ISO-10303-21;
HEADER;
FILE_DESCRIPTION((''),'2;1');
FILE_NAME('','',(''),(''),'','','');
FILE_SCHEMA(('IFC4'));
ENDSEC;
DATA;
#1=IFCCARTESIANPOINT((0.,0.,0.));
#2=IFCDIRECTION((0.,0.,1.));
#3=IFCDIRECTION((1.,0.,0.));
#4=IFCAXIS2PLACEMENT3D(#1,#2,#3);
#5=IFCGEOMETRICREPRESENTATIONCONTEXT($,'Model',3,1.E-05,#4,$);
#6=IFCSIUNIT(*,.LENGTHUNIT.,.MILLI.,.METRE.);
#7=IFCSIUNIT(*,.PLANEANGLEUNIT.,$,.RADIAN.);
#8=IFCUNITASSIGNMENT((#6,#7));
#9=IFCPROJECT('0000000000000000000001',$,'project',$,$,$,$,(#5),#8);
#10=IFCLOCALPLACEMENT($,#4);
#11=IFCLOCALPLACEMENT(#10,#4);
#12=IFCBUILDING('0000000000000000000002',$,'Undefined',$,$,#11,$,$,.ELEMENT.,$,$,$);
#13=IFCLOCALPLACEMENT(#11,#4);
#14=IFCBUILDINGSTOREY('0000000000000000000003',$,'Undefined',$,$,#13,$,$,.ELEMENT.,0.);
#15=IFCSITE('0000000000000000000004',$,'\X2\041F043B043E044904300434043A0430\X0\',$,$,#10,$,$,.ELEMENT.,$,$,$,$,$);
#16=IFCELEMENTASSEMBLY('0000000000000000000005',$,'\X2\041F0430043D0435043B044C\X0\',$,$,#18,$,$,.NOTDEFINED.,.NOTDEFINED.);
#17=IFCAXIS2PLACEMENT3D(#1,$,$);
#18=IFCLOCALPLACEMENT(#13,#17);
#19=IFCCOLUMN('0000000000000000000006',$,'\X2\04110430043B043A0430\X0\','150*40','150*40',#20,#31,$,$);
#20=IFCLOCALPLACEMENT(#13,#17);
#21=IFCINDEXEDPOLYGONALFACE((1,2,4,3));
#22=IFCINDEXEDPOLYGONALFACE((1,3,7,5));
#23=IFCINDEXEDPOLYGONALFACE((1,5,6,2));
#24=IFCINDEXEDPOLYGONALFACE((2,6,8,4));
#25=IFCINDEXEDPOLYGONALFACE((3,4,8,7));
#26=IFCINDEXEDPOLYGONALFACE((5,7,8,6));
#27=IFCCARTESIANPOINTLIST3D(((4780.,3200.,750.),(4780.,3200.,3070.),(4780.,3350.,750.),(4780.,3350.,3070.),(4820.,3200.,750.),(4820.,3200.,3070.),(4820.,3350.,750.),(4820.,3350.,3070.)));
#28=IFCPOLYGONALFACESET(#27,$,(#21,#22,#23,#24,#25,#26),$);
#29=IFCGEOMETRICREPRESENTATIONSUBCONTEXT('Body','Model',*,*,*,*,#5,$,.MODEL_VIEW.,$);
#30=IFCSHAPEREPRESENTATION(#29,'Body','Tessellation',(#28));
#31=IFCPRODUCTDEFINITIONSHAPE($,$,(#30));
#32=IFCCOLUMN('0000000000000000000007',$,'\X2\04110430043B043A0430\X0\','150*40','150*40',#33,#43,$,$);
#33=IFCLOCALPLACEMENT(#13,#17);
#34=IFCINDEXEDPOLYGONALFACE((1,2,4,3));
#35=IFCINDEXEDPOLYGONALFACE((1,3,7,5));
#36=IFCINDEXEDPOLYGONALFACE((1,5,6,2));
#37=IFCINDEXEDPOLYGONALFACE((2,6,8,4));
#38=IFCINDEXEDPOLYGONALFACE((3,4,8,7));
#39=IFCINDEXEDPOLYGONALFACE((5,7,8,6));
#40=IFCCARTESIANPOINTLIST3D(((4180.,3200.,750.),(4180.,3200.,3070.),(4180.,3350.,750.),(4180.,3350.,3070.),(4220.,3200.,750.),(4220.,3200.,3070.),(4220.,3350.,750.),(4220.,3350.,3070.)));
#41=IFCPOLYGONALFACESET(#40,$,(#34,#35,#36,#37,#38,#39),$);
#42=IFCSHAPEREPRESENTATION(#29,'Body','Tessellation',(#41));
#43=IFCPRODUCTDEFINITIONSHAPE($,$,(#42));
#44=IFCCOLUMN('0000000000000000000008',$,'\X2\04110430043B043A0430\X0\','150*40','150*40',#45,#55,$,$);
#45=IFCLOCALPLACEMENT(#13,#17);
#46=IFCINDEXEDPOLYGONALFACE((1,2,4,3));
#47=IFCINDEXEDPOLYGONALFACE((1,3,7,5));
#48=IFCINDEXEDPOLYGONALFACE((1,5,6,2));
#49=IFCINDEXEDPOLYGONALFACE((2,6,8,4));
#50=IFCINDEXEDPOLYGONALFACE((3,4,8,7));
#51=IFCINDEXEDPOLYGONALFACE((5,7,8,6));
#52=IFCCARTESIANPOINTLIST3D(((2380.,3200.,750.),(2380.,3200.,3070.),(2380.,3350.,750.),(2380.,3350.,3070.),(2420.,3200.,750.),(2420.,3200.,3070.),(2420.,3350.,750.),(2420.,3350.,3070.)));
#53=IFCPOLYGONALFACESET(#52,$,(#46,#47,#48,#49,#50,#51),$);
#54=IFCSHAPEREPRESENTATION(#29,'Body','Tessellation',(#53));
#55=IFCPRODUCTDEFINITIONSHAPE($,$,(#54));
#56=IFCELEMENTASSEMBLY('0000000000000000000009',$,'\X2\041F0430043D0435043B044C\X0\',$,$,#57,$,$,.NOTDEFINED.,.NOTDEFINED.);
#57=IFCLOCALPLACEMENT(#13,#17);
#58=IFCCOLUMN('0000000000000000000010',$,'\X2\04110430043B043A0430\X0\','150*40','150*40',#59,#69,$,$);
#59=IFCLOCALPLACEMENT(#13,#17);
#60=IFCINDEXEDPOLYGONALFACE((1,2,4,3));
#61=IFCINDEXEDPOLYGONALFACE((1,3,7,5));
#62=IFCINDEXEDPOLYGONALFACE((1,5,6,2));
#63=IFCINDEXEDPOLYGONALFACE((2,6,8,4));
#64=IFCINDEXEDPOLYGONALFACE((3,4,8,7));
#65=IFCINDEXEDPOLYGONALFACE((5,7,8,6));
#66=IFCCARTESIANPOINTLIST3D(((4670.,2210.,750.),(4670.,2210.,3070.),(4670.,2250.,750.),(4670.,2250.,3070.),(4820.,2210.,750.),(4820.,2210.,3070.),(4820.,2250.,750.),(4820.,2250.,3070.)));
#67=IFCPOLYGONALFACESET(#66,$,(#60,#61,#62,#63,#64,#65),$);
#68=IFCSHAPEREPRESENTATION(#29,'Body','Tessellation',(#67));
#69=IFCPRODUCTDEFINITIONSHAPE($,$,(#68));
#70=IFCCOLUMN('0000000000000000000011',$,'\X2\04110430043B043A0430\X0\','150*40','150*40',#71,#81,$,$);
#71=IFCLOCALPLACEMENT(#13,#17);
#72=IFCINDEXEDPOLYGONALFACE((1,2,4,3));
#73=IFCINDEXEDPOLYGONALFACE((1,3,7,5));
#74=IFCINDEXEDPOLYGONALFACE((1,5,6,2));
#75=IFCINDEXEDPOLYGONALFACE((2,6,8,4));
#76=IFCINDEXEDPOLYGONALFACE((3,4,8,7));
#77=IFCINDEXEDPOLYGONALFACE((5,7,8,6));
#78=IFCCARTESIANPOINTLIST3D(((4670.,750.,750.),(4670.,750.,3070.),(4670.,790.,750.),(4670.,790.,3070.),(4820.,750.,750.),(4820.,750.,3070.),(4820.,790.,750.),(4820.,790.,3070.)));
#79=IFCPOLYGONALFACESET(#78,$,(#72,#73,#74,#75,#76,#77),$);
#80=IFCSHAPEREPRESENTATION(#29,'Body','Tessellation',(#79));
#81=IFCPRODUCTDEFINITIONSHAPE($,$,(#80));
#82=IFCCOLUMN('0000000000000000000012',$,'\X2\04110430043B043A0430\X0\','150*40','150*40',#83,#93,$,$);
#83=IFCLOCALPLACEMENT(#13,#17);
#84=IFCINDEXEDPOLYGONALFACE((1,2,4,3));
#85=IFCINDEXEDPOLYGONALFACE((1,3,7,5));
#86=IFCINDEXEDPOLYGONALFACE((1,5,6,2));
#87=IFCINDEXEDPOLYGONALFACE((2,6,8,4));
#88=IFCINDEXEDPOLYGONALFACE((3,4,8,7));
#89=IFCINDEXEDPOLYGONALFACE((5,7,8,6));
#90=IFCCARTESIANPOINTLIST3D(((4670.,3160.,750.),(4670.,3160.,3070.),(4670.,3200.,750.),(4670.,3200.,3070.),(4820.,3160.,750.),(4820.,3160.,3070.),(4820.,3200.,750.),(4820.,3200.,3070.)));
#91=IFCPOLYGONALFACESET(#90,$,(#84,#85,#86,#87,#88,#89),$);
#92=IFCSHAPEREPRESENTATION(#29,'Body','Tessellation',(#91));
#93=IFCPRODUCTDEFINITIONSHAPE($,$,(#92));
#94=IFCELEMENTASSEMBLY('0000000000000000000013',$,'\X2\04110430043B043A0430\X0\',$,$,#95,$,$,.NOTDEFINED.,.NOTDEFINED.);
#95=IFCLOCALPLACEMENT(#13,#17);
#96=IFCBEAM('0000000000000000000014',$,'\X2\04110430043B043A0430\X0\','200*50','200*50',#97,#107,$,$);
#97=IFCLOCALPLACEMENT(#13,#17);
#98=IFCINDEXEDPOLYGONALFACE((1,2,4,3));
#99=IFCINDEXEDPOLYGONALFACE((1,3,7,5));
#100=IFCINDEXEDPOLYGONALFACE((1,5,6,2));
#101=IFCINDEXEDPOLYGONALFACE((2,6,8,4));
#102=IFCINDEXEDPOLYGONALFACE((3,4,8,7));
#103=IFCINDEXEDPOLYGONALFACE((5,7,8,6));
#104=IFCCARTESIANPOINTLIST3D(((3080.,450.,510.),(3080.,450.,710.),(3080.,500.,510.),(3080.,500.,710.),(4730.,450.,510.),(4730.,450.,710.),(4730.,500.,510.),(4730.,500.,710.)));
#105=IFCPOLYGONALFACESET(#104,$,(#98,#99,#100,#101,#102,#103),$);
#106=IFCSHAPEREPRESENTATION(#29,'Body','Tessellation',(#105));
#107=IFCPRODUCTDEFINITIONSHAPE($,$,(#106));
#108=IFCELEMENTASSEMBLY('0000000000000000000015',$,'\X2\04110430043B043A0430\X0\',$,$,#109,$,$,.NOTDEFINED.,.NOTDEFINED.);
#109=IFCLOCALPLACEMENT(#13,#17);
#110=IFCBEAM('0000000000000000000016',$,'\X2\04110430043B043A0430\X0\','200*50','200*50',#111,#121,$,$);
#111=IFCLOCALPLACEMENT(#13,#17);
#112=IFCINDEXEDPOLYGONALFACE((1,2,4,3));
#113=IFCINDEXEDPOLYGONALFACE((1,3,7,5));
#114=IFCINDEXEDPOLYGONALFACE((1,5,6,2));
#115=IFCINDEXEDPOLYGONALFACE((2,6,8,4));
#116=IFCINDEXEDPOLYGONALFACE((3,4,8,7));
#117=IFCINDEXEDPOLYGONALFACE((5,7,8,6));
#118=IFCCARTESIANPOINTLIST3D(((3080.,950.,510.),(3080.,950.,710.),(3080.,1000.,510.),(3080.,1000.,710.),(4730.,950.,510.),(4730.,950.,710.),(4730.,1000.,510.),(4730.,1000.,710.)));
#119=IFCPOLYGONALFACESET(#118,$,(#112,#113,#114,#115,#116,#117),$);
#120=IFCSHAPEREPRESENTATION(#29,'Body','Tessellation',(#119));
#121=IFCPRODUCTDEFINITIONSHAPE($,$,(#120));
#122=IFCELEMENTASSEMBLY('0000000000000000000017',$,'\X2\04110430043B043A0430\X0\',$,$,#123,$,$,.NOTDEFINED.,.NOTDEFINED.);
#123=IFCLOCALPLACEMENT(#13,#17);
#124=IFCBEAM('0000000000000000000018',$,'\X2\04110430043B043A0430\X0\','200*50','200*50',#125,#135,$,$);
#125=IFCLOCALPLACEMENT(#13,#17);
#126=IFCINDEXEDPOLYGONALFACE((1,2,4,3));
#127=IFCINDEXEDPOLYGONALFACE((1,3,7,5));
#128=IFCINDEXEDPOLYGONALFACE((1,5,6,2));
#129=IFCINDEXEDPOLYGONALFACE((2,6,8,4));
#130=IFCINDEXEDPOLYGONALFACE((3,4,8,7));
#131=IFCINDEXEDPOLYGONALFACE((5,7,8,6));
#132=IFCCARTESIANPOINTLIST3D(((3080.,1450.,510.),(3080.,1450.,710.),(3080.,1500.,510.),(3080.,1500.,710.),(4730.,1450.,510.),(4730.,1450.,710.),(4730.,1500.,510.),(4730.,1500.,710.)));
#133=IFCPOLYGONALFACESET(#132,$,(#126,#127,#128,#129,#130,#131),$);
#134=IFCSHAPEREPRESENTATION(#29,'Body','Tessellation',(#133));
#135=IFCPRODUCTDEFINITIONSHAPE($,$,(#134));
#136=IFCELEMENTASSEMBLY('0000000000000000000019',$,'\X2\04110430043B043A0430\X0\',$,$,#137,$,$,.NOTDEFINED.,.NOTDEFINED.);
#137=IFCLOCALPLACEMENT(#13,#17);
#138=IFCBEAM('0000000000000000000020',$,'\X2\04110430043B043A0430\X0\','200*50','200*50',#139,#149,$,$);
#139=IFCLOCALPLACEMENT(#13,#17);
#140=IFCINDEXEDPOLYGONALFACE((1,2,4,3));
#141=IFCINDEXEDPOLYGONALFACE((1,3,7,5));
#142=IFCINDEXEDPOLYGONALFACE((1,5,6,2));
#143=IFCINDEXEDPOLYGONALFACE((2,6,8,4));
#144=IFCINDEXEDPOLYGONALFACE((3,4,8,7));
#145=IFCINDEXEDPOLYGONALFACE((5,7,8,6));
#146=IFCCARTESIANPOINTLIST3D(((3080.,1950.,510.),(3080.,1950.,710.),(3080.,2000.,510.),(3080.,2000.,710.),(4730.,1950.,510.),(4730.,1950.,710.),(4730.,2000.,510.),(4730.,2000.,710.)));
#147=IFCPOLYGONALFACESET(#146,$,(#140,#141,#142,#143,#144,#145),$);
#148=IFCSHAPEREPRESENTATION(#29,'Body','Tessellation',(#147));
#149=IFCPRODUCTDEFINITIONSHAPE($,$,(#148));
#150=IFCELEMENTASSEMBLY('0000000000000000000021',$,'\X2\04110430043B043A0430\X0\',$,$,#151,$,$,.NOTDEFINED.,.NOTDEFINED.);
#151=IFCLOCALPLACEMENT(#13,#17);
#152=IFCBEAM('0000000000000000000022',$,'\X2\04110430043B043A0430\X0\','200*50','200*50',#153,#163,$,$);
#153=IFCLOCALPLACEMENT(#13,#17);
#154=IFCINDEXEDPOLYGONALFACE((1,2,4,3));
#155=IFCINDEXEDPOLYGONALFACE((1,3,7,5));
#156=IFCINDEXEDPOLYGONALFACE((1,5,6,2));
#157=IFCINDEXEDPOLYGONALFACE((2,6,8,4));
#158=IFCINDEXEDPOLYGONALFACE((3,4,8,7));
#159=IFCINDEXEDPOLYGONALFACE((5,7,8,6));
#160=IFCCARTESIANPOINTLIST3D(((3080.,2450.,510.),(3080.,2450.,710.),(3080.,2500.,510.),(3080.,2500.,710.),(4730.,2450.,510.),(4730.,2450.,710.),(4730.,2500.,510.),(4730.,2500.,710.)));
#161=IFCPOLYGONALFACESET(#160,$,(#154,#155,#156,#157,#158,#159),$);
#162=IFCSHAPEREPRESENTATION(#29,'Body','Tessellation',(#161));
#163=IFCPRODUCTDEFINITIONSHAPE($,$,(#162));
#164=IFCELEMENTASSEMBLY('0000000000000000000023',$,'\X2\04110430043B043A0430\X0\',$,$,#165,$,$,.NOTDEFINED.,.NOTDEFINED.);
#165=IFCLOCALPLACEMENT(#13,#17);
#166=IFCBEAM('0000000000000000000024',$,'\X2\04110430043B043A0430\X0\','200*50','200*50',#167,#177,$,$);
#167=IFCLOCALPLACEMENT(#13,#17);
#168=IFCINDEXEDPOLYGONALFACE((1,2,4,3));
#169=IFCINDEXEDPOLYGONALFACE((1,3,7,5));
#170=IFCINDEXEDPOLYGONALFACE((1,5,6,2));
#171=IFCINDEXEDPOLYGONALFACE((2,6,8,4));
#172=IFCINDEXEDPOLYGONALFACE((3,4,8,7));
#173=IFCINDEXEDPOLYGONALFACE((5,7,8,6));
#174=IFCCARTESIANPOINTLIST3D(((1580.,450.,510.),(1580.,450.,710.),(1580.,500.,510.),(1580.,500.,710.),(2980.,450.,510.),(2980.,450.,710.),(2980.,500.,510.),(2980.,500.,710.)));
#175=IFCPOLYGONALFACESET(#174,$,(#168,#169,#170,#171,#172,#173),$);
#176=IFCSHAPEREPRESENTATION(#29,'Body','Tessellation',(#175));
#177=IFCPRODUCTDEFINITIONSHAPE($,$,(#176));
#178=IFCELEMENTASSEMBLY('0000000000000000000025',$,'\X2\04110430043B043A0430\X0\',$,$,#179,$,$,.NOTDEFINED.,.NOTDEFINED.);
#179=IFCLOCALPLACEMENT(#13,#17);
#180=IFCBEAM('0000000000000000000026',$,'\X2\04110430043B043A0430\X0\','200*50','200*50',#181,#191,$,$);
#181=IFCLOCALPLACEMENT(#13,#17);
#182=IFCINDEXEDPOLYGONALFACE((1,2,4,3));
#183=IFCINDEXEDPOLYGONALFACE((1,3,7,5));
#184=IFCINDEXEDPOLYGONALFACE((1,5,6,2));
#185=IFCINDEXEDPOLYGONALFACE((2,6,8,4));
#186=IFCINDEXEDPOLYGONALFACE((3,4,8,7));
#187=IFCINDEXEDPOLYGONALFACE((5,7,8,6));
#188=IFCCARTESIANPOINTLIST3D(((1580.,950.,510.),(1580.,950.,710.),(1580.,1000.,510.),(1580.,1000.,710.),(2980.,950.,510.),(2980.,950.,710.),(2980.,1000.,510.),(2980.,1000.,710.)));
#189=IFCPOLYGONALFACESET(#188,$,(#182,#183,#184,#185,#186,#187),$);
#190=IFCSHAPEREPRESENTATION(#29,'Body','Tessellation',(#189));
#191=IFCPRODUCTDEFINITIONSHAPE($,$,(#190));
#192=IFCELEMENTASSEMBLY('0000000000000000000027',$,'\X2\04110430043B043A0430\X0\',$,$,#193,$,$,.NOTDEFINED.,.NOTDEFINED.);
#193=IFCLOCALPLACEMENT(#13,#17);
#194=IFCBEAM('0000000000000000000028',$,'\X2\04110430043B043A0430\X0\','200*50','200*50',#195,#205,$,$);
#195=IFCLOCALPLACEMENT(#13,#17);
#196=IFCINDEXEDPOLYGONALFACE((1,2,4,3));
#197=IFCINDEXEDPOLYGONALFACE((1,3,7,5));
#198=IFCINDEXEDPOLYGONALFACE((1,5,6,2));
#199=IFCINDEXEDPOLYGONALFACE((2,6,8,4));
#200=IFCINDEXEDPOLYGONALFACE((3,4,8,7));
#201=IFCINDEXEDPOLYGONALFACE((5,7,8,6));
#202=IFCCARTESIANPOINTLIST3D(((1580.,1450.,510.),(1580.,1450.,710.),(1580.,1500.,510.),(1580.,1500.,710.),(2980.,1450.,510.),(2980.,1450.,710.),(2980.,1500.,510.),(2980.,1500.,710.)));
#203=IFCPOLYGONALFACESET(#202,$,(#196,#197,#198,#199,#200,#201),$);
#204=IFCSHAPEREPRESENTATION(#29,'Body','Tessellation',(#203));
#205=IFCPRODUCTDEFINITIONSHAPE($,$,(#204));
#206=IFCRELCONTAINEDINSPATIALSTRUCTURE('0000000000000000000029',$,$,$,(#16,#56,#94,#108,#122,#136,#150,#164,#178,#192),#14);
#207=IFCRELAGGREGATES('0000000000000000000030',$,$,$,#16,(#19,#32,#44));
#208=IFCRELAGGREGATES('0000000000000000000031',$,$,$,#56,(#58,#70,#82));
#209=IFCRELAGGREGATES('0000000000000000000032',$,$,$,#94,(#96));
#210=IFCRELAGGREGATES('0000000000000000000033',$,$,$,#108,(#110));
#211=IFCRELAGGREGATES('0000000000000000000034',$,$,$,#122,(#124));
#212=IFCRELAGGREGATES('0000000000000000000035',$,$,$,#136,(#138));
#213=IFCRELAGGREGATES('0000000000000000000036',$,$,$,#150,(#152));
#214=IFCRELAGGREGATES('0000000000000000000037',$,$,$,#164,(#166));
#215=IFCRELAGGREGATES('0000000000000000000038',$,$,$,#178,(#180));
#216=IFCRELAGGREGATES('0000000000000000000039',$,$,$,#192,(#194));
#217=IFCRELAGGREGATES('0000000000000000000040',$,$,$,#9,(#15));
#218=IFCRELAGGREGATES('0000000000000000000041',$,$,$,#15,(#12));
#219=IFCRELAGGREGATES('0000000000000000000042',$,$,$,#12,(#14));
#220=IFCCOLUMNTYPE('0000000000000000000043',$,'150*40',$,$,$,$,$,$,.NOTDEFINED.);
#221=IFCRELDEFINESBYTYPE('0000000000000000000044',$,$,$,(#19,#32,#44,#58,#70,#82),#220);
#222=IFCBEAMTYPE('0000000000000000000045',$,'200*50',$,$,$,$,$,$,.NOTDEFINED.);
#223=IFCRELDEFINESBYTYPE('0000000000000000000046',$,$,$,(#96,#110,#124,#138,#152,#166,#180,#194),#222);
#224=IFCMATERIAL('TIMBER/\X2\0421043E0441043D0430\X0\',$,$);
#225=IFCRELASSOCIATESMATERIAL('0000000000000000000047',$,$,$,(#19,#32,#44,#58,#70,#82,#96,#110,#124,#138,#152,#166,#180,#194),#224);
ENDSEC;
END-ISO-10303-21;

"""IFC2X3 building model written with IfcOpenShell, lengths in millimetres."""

from ifc_helpers import new_model, si_unit, frame, origin_with_axes, origin_2d_with_axis, place, context, subcontext, project, spatial, rectangle, extrude, material, type_object, element, aggregate, save


model = new_model("IFC2X3")

# Units and contexts
model_context = context("Model", 3, precision=1e-05, world=origin_with_axes())
body_context = subcontext(model_context, "Body", "Model", "MODEL_VIEW")
ifc_project = project(units=[si_unit("LENGTHUNIT", "METRE", prefix="MILLI"), si_unit("PLANEANGLEUNIT", "RADIAN")], contexts=[model_context])

# Site, building, storey
site_placement = place(None, origin_with_axes())
site = spatial("IfcSite", under=ifc_project, at=site_placement, Name="Площадка", CompositionType="ELEMENT")
building_placement = place(site_placement, origin_with_axes())
building = spatial("IfcBuilding", under=site, at=building_placement, Name="Undefined", CompositionType="ELEMENT")
storey_placement = place(building_placement, origin_with_axes())
storey = spatial("IfcBuildingStorey", under=building, at=storey_placement, Name="Undefined", CompositionType="ELEMENT", Elevation=0.0)

# Element assemblies, columns
assembly_1_placement = place(storey_placement, origin_with_axes())
assembly_1 = element("IfcElementAssembly", 1, at=assembly_1_placement, inside=storey, Name="Панель", AssemblyPlace="NOTDEFINED", PredefinedType="NOTDEFINED")
ifc_material_1 = material(Name="TIMBER/Сосна")
column_type = type_object("IfcColumnType", Name="150*40", PredefinedType="NOTDEFINED")
column_1_placement = place(assembly_1_placement, frame((4800.0, 3275.0, 750.0), z_axis=(0.0, 0.0, 1.0), x_axis=(0.0, 1.0, 0.0)))
column_1 = element("IfcColumn", 2, at=column_1_placement, type_object=column_type, material=ifc_material_1, Name="Балка", Description="150*40", ObjectType="150*40", context=body_context, shape_type="SweptSolid", body=[
    extrude(rectangle(XDim=40.0, YDim=150.0, at=origin_2d_with_axis()), frame((0.0, 0.0, 2320.0), z_axis=(0.0, 0.0, -1.0), x_axis=(0.0, 1.0, 0.0)), (0.0, 0.0, 1.0), 2320.0),
])
column_2_placement = place(assembly_1_placement, frame((4200.0, 3275.0, 750.0), z_axis=(0.0, 0.0, 1.0), x_axis=(0.0, 1.0, 0.0)))
column_2 = element("IfcColumn", 3, at=column_2_placement, type_object=column_type, material=ifc_material_1, Name="Балка", Description="150*40", ObjectType="150*40", context=body_context, shape_type="SweptSolid", body=[
    extrude(rectangle(XDim=40.0, YDim=150.0, at=origin_2d_with_axis()), frame((0.0, 0.0, 2320.0), z_axis=(0.0, 0.0, -1.0), x_axis=(0.0, 1.0, 0.0)), (0.0, 0.0, 1.0), 2320.0),
])
column_3_placement = place(assembly_1_placement, frame((2400.0, 3275.0, 750.0), z_axis=(0.0, 0.0, 1.0), x_axis=(0.0, 1.0, 0.0)))
column_3 = element("IfcColumn", 4, at=column_3_placement, type_object=column_type, material=ifc_material_1, Name="Балка", Description="150*40", ObjectType="150*40", context=body_context, shape_type="SweptSolid", body=[
    extrude(rectangle(XDim=40.0, YDim=150.0, at=origin_2d_with_axis()), frame((0.0, 0.0, 2320.0), z_axis=(0.0, 0.0, -1.0), x_axis=(0.0, 1.0, 0.0)), (0.0, 0.0, 1.0), 2320.0),
])
aggregate(assembly_1, [column_1, column_2, column_3])
assembly_2_placement = place(storey_placement, origin_with_axes())
assembly_2 = element("IfcElementAssembly", 5, at=assembly_2_placement, inside=storey, Name="Панель", AssemblyPlace="NOTDEFINED", PredefinedType="NOTDEFINED")
column_4_placement = place(assembly_2_placement, frame((4745.0, 2230.0, 750.0), z_axis=(0.0, 0.0, 1.0), x_axis=(-1.0, 0.0, 0.0)))
column_4 = element("IfcColumn", 6, at=column_4_placement, type_object=column_type, material=ifc_material_1, Name="Балка", Description="150*40", ObjectType="150*40", context=body_context, shape_type="SweptSolid", body=[
    extrude(rectangle(XDim=40.0, YDim=150.0, at=origin_2d_with_axis()), frame((0.0, 0.0, 2320.0), z_axis=(0.0, 0.0, -1.0), x_axis=(0.0, 1.0, 0.0)), (0.0, 0.0, 1.0), 2320.0),
])
column_5_placement = place(assembly_2_placement, frame((4745.0, 770.0, 750.0), z_axis=(0.0, 0.0, 1.0), x_axis=(-1.0, 0.0, 0.0)))
column_5 = element("IfcColumn", 7, at=column_5_placement, type_object=column_type, material=ifc_material_1, Name="Балка", Description="150*40", ObjectType="150*40", context=body_context, shape_type="SweptSolid", body=[
    extrude(rectangle(XDim=40.0, YDim=150.0, at=origin_2d_with_axis()), frame((0.0, 0.0, 2320.0), z_axis=(0.0, 0.0, -1.0), x_axis=(0.0, 1.0, 0.0)), (0.0, 0.0, 1.0), 2320.0),
])
column_6_placement = place(assembly_2_placement, frame((4745.0, 3180.0, 750.0), z_axis=(0.0, 0.0, 1.0), x_axis=(-1.0, 0.0, 0.0)))
column_6 = element("IfcColumn", 8, at=column_6_placement, type_object=column_type, material=ifc_material_1, Name="Балка", Description="150*40", ObjectType="150*40", context=body_context, shape_type="SweptSolid", body=[
    extrude(rectangle(XDim=40.0, YDim=150.0, at=origin_2d_with_axis()), frame((0.0, 0.0, 2320.0), z_axis=(0.0, 0.0, -1.0), x_axis=(0.0, 1.0, 0.0)), (0.0, 0.0, 1.0), 2320.0),
])
aggregate(assembly_2, [column_4, column_5, column_6])

# Element assemblies, beams
assembly_3_placement = place(storey_placement, origin_with_axes())
assembly_3 = element("IfcElementAssembly", 9, at=assembly_3_placement, inside=storey, Name="Балка", AssemblyPlace="NOTDEFINED", PredefinedType="NOTDEFINED")
beam_type = type_object("IfcBeamType", Name="200*50", PredefinedType="NOTDEFINED")
beam_1_placement = place(assembly_3_placement, frame((4730.0, 475.0, 610.0), z_axis=(0.0, 0.0, -1.0), x_axis=(-1.0, 0.0, 0.0)))
beam_1 = element("IfcBeam", 10, at=beam_1_placement, type_object=beam_type, material=ifc_material_1, Name="Балка", Description="200*50", ObjectType="200*50", context=body_context, shape_type="SweptSolid", body=[
    extrude(rectangle(XDim=50.0, YDim=200.0, at=origin_2d_with_axis()), frame((1650.0, 0.0, 0.0), z_axis=(-1.0, 0.0, 0.0), x_axis=(0.0, -1.0, 0.0)), (0.0, 0.0, 1.0), 1650.0),
])
aggregate(assembly_3, [beam_1])
assembly_4_placement = place(storey_placement, origin_with_axes())
assembly_4 = element("IfcElementAssembly", 11, at=assembly_4_placement, inside=storey, Name="Балка", AssemblyPlace="NOTDEFINED", PredefinedType="NOTDEFINED")
beam_2_placement = place(assembly_4_placement, frame((4730.0, 975.0, 610.0), z_axis=(0.0, 0.0, -1.0), x_axis=(-1.0, 0.0, 0.0)))
beam_2 = element("IfcBeam", 12, at=beam_2_placement, type_object=beam_type, material=ifc_material_1, Name="Балка", Description="200*50", ObjectType="200*50", context=body_context, shape_type="SweptSolid", body=[
    extrude(rectangle(XDim=50.0, YDim=200.0, at=origin_2d_with_axis()), frame((1650.0, 0.0, 0.0), z_axis=(-1.0, 0.0, 0.0), x_axis=(0.0, -1.0, 0.0)), (0.0, 0.0, 1.0), 1650.0),
])
aggregate(assembly_4, [beam_2])
assembly_5_placement = place(storey_placement, origin_with_axes())
assembly_5 = element("IfcElementAssembly", 13, at=assembly_5_placement, inside=storey, Name="Балка", AssemblyPlace="NOTDEFINED", PredefinedType="NOTDEFINED")
beam_3_placement = place(assembly_5_placement, frame((4730.0, 1475.0, 610.0), z_axis=(0.0, 0.0, -1.0), x_axis=(-1.0, 0.0, 0.0)))
beam_3 = element("IfcBeam", 14, at=beam_3_placement, type_object=beam_type, material=ifc_material_1, Name="Балка", Description="200*50", ObjectType="200*50", context=body_context, shape_type="SweptSolid", body=[
    extrude(rectangle(XDim=50.0, YDim=200.0, at=origin_2d_with_axis()), frame((1650.0, 0.0, 0.0), z_axis=(-1.0, 0.0, 0.0), x_axis=(0.0, -1.0, 0.0)), (0.0, 0.0, 1.0), 1650.0),
])
aggregate(assembly_5, [beam_3])
assembly_6_placement = place(storey_placement, origin_with_axes())
assembly_6 = element("IfcElementAssembly", 15, at=assembly_6_placement, inside=storey, Name="Балка", AssemblyPlace="NOTDEFINED", PredefinedType="NOTDEFINED")
beam_4_placement = place(assembly_6_placement, frame((4730.0, 1975.0, 610.0), z_axis=(0.0, 0.0, -1.0), x_axis=(-1.0, 0.0, 0.0)))
beam_4 = element("IfcBeam", 16, at=beam_4_placement, type_object=beam_type, material=ifc_material_1, Name="Балка", Description="200*50", ObjectType="200*50", context=body_context, shape_type="SweptSolid", body=[
    extrude(rectangle(XDim=50.0, YDim=200.0, at=origin_2d_with_axis()), frame((1650.0, 0.0, 0.0), z_axis=(-1.0, 0.0, 0.0), x_axis=(0.0, -1.0, 0.0)), (0.0, 0.0, 1.0), 1650.0),
])
aggregate(assembly_6, [beam_4])
assembly_7_placement = place(storey_placement, origin_with_axes())
assembly_7 = element("IfcElementAssembly", 17, at=assembly_7_placement, inside=storey, Name="Балка", AssemblyPlace="NOTDEFINED", PredefinedType="NOTDEFINED")
beam_5_placement = place(assembly_7_placement, frame((4730.0, 2475.0, 610.0), z_axis=(0.0, 0.0, -1.0), x_axis=(-1.0, 0.0, 0.0)))
beam_5 = element("IfcBeam", 18, at=beam_5_placement, type_object=beam_type, material=ifc_material_1, Name="Балка", Description="200*50", ObjectType="200*50", context=body_context, shape_type="SweptSolid", body=[
    extrude(rectangle(XDim=50.0, YDim=200.0, at=origin_2d_with_axis()), frame((1650.0, 0.0, 0.0), z_axis=(-1.0, 0.0, 0.0), x_axis=(0.0, -1.0, 0.0)), (0.0, 0.0, 1.0), 1650.0),
])
aggregate(assembly_7, [beam_5])
assembly_8_placement = place(storey_placement, origin_with_axes())
assembly_8 = element("IfcElementAssembly", 19, at=assembly_8_placement, inside=storey, Name="Балка", AssemblyPlace="NOTDEFINED", PredefinedType="NOTDEFINED")
beam_6_placement = place(assembly_8_placement, frame((2980.0, 475.0, 610.0), z_axis=(0.0, 0.0, -1.0), x_axis=(-1.0, 0.0, 0.0)))
beam_6 = element("IfcBeam", 20, at=beam_6_placement, type_object=beam_type, material=ifc_material_1, Name="Балка", Description="200*50", ObjectType="200*50", context=body_context, shape_type="SweptSolid", body=[
    extrude(rectangle(XDim=50.0, YDim=200.0, at=origin_2d_with_axis()), frame((1400.0, 0.0, 0.0), z_axis=(-1.0, 0.0, 0.0), x_axis=(0.0, -1.0, 0.0)), (0.0, 0.0, 1.0), 1400.0),
])
aggregate(assembly_8, [beam_6])
assembly_9_placement = place(storey_placement, origin_with_axes())
assembly_9 = element("IfcElementAssembly", 21, at=assembly_9_placement, inside=storey, Name="Балка", AssemblyPlace="NOTDEFINED", PredefinedType="NOTDEFINED")
beam_7_placement = place(assembly_9_placement, frame((2980.0, 975.0, 610.0), z_axis=(0.0, 0.0, -1.0), x_axis=(-1.0, 0.0, 0.0)))
beam_7 = element("IfcBeam", 22, at=beam_7_placement, type_object=beam_type, material=ifc_material_1, Name="Балка", Description="200*50", ObjectType="200*50", context=body_context, shape_type="SweptSolid", body=[
    extrude(rectangle(XDim=50.0, YDim=200.0, at=origin_2d_with_axis()), frame((1400.0, 0.0, 0.0), z_axis=(-1.0, 0.0, 0.0), x_axis=(0.0, -1.0, 0.0)), (0.0, 0.0, 1.0), 1400.0),
])
aggregate(assembly_9, [beam_7])
assembly_10_placement = place(storey_placement, origin_with_axes())
assembly_10 = element("IfcElementAssembly", 23, at=assembly_10_placement, inside=storey, Name="Балка", AssemblyPlace="NOTDEFINED", PredefinedType="NOTDEFINED")
beam_8_placement = place(assembly_10_placement, frame((2980.0, 1475.0, 610.0), z_axis=(0.0, 0.0, -1.0), x_axis=(-1.0, 0.0, 0.0)))
beam_8 = element("IfcBeam", 24, at=beam_8_placement, type_object=beam_type, material=ifc_material_1, Name="Балка", Description="200*50", ObjectType="200*50", context=body_context, shape_type="SweptSolid", body=[
    extrude(rectangle(XDim=50.0, YDim=200.0, at=origin_2d_with_axis()), frame((1400.0, 0.0, 0.0), z_axis=(-1.0, 0.0, 0.0), x_axis=(0.0, -1.0, 0.0)), (0.0, 0.0, 1.0), 1400.0),
])
aggregate(assembly_10, [beam_8])

save(model, "model.ifc")
